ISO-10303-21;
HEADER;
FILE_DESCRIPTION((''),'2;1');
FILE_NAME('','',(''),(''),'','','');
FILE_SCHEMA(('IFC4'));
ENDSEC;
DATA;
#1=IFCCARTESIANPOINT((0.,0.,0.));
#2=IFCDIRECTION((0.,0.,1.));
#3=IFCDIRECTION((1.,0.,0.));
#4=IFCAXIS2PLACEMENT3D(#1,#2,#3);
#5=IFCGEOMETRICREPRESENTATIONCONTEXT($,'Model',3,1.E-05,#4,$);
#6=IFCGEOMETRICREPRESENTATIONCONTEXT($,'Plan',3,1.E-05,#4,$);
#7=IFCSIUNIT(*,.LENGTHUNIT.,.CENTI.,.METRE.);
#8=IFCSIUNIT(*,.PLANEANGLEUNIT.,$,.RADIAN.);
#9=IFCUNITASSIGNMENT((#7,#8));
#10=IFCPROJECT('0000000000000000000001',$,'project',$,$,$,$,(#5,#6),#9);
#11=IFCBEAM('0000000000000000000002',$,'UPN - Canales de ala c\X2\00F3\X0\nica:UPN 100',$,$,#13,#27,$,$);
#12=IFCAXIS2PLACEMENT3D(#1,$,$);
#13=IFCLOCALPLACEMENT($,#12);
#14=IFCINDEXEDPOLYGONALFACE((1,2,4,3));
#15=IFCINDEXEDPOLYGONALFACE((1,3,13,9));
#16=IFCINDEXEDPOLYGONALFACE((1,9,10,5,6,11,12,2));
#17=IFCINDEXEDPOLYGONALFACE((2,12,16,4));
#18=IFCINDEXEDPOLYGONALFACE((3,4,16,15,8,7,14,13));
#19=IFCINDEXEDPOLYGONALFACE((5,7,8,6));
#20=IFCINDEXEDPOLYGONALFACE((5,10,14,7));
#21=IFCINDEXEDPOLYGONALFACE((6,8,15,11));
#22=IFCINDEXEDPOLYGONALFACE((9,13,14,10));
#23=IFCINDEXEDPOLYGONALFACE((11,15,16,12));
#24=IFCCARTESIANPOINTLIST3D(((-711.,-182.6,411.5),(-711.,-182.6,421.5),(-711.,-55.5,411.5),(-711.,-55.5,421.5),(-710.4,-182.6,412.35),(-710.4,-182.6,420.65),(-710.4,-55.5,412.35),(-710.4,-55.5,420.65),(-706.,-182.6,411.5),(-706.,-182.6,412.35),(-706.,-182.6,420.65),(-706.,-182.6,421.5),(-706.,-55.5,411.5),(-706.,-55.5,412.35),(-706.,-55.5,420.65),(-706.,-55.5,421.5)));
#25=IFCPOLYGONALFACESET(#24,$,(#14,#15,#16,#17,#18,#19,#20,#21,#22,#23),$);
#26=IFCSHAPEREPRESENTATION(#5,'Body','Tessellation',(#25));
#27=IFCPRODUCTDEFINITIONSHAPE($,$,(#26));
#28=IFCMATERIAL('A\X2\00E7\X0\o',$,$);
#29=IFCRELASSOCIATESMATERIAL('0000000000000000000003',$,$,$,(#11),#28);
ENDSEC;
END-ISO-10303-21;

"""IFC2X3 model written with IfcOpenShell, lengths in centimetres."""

from ifc_helpers import new_model, si_unit, frame, origin_with_axes, origin_2d_with_axis, place, context, project, u_section, extrude, material, element, save


model = new_model("IFC2X3")

# Units and contexts
model_context = context("Model", 3, precision=1e-05, world=origin_with_axes())
plan_context = context("Plan", 3, precision=1e-05, world=origin_with_axes())
ifc_project = project(units=[si_unit("LENGTHUNIT", "METRE", prefix="CENTI"), si_unit("PLANEANGLEUNIT", "RADIAN")], contexts=[model_context, plan_context])

# Shared definitions
ifc_material = material(Name="Aço")

# Beam
for number, where, z_axis, x_axis, name in (
    (1, (-708.5, -182.6, 416.5), (0.0, 1.0, 0.0), (1.0, 0.0, 0.0), "UPN - Canales de ala cónica:UPN 100"),
):
    element("IfcBeam", number, at=place(None, frame(where, z_axis=z_axis, x_axis=x_axis)), material=ifc_material, Name=name, context=model_context, shape_type="SweptSolid", body=[
        extrude(u_section(Depth=10.0, FlangeWidth=5.0, WebThickness=0.6, FlangeThickness=0.85, FilletRadius=0.0, EdgeRadius=0.0, FlangeSlope=0.0, CentreOfGravityInX=0.0, at=origin_2d_with_axis()), origin_with_axes(), (0.0, 0.0, 1.0), 127.1),
    ])

save(model, "model.ifc")
